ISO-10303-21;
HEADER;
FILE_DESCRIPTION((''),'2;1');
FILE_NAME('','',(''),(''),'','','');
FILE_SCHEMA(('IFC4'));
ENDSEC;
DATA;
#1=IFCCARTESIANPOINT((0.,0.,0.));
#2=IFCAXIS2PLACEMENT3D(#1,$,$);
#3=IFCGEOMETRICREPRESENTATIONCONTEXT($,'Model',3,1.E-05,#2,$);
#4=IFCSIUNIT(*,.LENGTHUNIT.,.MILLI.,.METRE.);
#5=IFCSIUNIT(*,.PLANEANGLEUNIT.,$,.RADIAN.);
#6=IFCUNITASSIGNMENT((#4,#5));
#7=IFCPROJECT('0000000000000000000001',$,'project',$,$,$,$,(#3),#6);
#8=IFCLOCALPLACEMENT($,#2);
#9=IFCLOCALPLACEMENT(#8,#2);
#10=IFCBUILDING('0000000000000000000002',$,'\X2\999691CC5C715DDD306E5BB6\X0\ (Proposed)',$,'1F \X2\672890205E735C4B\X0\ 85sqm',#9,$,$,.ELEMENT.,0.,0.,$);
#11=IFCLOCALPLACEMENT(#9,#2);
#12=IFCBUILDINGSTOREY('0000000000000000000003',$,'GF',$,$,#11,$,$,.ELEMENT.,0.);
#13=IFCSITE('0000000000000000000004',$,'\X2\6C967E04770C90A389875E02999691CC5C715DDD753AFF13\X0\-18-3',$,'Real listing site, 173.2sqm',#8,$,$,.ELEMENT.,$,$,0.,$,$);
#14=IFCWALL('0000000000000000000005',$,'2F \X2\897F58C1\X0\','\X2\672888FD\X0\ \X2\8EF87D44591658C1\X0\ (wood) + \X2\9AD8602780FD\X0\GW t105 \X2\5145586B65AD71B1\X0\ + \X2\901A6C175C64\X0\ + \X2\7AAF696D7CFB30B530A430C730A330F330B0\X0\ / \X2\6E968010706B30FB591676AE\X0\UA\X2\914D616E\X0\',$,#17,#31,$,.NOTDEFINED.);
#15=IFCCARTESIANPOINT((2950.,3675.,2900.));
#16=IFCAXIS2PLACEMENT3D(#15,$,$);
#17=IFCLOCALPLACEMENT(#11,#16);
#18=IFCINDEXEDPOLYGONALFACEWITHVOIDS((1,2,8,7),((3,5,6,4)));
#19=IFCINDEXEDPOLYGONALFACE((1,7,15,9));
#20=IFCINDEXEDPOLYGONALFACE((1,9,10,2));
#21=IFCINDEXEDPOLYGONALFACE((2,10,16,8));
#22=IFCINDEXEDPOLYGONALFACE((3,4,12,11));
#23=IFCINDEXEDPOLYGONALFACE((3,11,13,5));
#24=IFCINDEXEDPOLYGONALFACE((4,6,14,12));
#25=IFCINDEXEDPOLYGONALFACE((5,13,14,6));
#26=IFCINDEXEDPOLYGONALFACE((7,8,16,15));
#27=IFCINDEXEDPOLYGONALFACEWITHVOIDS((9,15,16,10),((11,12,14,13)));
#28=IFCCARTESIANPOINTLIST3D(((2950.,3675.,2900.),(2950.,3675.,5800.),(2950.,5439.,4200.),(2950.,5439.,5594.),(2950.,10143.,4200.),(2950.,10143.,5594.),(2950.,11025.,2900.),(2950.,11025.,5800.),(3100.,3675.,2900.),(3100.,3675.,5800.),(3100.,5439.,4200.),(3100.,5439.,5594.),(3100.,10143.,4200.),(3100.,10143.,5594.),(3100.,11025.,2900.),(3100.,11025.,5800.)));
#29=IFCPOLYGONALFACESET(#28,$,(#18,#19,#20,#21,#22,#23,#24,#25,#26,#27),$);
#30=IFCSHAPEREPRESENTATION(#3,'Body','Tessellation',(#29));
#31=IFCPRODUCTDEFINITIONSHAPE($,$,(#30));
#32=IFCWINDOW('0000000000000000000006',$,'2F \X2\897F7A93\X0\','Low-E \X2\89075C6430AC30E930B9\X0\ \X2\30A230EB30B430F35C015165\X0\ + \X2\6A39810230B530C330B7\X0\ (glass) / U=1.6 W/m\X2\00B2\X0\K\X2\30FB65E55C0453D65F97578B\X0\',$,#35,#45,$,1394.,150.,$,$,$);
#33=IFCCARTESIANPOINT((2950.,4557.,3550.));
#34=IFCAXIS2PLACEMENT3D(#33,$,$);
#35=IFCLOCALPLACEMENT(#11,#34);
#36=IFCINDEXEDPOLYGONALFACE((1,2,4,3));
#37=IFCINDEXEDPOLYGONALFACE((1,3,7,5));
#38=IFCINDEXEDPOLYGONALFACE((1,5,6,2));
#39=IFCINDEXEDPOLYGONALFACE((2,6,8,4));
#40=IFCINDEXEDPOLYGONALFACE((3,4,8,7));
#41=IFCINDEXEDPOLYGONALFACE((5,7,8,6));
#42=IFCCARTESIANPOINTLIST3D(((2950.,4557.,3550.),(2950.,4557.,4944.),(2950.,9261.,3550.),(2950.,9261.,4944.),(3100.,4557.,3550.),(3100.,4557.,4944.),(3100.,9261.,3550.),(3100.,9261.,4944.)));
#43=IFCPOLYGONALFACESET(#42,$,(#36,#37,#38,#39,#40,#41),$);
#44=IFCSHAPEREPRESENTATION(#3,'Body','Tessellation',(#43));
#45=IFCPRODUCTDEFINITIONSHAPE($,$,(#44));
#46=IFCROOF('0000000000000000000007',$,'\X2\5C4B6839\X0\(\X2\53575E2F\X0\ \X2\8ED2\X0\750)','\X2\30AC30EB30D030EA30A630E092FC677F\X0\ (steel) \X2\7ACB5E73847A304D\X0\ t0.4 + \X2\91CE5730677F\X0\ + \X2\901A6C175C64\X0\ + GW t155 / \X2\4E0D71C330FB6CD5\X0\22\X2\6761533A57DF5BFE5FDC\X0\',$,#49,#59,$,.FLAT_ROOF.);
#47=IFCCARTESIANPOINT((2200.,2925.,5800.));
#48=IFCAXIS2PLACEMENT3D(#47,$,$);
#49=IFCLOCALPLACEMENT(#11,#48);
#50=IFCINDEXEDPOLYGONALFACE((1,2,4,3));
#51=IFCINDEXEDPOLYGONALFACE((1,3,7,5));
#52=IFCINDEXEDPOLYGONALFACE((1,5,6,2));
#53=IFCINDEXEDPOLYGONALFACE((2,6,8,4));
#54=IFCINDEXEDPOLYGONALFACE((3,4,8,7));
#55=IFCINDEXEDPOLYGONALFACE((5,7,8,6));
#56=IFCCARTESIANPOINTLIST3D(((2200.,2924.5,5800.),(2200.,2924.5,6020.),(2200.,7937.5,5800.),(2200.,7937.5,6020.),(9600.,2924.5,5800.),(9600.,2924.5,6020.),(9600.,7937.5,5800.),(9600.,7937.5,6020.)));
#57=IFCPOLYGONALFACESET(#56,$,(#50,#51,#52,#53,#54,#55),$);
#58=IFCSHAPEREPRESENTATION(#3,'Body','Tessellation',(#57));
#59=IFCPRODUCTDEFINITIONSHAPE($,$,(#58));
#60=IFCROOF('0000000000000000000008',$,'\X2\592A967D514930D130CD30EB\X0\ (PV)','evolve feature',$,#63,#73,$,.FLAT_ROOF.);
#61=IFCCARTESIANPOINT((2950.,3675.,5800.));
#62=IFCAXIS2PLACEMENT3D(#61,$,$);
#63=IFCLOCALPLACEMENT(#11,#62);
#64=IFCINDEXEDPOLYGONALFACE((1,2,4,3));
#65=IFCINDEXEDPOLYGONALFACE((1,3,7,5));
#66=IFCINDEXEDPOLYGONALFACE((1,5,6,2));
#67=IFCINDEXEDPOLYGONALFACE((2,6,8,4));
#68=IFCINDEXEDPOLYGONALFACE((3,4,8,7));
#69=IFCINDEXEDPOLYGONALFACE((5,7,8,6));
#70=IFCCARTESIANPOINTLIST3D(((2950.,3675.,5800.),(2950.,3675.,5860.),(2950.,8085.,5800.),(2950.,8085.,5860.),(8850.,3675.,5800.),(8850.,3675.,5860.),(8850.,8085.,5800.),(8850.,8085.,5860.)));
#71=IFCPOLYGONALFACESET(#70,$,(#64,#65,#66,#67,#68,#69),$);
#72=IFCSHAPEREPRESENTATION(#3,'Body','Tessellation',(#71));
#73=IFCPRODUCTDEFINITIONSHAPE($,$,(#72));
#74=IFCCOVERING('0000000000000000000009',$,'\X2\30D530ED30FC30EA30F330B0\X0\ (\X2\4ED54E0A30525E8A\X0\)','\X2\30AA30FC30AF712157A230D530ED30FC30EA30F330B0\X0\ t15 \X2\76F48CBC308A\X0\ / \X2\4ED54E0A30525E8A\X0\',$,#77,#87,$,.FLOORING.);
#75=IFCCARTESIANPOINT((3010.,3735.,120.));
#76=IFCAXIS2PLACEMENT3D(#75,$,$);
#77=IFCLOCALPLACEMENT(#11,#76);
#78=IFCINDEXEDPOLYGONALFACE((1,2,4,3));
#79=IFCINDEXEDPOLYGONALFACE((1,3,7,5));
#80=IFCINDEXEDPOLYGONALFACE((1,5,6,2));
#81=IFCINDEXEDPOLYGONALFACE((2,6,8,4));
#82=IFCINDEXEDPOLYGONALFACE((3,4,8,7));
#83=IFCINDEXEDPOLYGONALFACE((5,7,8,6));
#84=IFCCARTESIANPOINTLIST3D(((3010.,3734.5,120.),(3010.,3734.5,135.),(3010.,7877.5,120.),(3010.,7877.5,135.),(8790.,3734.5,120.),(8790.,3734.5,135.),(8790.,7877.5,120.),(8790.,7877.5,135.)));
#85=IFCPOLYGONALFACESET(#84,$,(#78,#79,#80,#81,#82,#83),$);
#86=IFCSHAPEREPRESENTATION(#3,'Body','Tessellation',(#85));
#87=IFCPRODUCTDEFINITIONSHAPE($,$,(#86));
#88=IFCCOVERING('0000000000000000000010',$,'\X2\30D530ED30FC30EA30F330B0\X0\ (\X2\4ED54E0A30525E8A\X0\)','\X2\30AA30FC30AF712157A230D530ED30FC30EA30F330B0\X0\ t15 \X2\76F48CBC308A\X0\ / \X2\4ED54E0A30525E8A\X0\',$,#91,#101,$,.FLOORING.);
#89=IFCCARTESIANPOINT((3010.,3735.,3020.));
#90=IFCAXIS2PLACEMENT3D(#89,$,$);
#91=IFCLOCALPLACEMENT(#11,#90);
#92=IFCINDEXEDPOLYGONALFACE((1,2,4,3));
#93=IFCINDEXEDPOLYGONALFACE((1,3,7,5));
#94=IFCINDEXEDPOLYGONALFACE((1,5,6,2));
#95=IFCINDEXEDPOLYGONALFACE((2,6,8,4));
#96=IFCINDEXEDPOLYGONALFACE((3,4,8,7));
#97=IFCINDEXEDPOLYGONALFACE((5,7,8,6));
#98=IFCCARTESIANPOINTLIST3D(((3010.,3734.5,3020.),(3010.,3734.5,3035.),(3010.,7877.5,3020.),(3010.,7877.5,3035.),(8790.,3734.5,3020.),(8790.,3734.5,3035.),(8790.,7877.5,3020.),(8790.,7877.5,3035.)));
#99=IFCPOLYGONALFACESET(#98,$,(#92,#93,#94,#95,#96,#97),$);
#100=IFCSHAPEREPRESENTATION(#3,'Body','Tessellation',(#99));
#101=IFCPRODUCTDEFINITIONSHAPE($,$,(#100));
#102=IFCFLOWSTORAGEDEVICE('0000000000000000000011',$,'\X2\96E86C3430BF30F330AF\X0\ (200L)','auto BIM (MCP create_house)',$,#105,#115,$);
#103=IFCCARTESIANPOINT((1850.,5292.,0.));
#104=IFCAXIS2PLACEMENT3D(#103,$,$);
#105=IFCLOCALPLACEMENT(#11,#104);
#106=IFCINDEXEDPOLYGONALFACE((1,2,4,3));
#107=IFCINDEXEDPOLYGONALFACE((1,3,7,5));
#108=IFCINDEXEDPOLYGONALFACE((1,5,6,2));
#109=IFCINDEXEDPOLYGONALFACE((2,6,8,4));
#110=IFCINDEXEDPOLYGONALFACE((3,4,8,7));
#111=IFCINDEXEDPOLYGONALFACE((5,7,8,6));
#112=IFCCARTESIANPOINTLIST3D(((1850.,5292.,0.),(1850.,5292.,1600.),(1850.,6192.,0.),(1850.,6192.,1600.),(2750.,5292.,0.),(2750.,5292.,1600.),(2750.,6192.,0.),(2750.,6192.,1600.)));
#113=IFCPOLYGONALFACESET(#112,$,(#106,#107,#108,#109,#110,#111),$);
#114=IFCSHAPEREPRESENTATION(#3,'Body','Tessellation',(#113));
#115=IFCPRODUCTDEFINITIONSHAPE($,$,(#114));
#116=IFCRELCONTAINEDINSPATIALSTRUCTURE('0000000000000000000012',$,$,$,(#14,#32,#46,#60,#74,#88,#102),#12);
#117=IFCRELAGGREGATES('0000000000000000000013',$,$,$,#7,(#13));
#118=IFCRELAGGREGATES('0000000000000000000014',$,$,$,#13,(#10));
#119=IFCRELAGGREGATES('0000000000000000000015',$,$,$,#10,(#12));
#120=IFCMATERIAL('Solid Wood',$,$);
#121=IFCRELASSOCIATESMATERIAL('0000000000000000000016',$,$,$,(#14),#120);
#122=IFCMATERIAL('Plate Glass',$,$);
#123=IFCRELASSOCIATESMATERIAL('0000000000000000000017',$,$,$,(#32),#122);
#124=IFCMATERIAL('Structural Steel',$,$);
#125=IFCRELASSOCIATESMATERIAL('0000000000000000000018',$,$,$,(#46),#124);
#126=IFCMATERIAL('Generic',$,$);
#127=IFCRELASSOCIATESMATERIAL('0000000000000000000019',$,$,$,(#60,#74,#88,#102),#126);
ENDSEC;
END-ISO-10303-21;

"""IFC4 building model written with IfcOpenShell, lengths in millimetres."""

from ifc_helpers import new_model, si_unit, frame, frame_2d, origin, place, context, project, spatial, rectangle, extrude, material, element, fill, save


model = new_model("IFC4")

# Units and contexts
model_context = context("Model", 3, precision=1e-05, world=origin())
ifc_project = project(units=[si_unit("LENGTHUNIT", "METRE", prefix="MILLI"), si_unit("PLANEANGLEUNIT", "RADIAN")], contexts=[model_context])

# Site, building, storey
site_placement = place(None, origin())
site = spatial("IfcSite", under=ifc_project, at=site_placement, Name="沖縄県那覇市首里山川町３-18-3", ObjectType="Real listing site, 173.2sqm", CompositionType="ELEMENT", RefElevation=0.0)
building_placement = place(site_placement, origin())
building = spatial("IfcBuilding", under=site, at=building_placement, Name="首里山川の家 (Proposed)", ObjectType="1F 木造平屋 85sqm", CompositionType="ELEMENT", ElevationOfRefHeight=0.0, ElevationOfTerrain=0.0)
storey_placement = place(building_placement, origin())
storey = spatial("IfcBuildingStorey", under=building, at=storey_placement, Name="GF", CompositionType="ELEMENT", Elevation=0.0)

# Shared definitions
ifc_material_1 = material(Name="Solid Wood")
ifc_material_2 = material(Name="Generic")

# Shared definitions
ifc_material_3 = material(Name="Plate Glass")

# Wall, opening, window
wall_1_placement = place(storey_placement, frame((2950.0, 3675.0, 2900.0)))
wall_1 = element("IfcWall", 1, at=wall_1_placement, inside=storey, material=ifc_material_1, Name="2F 西壁", Description="木製 軸組外壁 (wood) + 高性能GW t105 充填断熱 + 通気層 + 窯業系サイディング / 準耐火・外皮UA配慮", PredefinedType="NOTDEFINED", context=model_context, shape_type="SweptSolid", body=[
    extrude(rectangle(XDim=150.0, YDim=7350.0, at=frame_2d((75.0, 3675.0))), frame((2950.0, 3675.0, 2900.0)), (0.0, 0.0, 1.0), 2900.0),
])
opening_1_placement = place(storey_placement, frame((2950.0, 4557.0, 3550.0)))
opening_1 = element("IfcOpeningElement", 2, at=opening_1_placement, cuts=wall_1, PredefinedType="NOTDEFINED", context=model_context, shape_type="SweptSolid", body=[
    extrude(rectangle(XDim=150.0, YDim=4704.0, at=frame_2d((75.0, 2352.0))), frame((2950.0, 4557.0, 3550.0)), (0.0, 0.0, 1.0), 1394.0),
])
window_1_placement = place(storey_placement, frame((2950.0, 4557.0, 3550.0)))
window_1 = element("IfcWindow", 3, at=window_1_placement, inside=storey, material=ifc_material_3, Name="2F 西窓", Description="Low-E 複層ガラス アルゴン封入 + 樹脂サッシ (glass) / U=1.6 W/m²K・日射取得型", OverallHeight=1394.0, OverallWidth=150.0, context=model_context, shape_type="SweptSolid", body=[
    extrude(rectangle(XDim=150.0, YDim=4704.0, at=frame_2d((75.0, 2352.0))), frame((2950.0, 4557.0, 3550.0)), (0.0, 0.0, 1.0), 1394.0),
])
fill(opening_1, window_1)

# Roofs
ifc_material_4 = material(Name="Structural Steel")
for number, where, name in (
    (4, (2200.0, 2925.0, 5800.0), "屋根(南帯 軒750)"),
):
    element("IfcRoof", number, at=place(storey_placement, frame(where)), inside=storey, material=ifc_material_4, Name=name, Description="ガルバリウム鋼板 (steel) 立平葺き t0.4 + 野地板 + 通気層 + GW t155 / 不燃・法22条区域対応", PredefinedType="FLAT_ROOF", context=model_context, shape_type="SweptSolid", body=[
        extrude(rectangle(XDim=7400.0, YDim=5013.0, at=frame_2d((3700.0, 2506.0))), frame((2200.0, 2925.0, 5800.0)), (0.0, 0.0, 1.0), 220.0),
    ])
roof_placement = place(storey_placement, frame((2950.0, 3675.0, 5800.0)))
element("IfcRoof", 5, at=roof_placement, inside=storey, material=ifc_material_2, Name="太陽光パネル (PV)", Description="evolve feature", PredefinedType="FLAT_ROOF", context=model_context, shape_type="SweptSolid", body=[
    extrude(rectangle(XDim=5900.0, YDim=4410.0, at=frame_2d((2950.0, 2205.0))), frame((2950.0, 3675.0, 5800.0)), (0.0, 0.0, 1.0), 60.0),
])

# Coverings
covering_1_placement = place(storey_placement, frame((3010.0, 3735.0, 120.0)))
element("IfcCovering", 6, at=covering_1_placement, inside=storey, material=ifc_material_2, Name="フローリング (仕上げ床)", Description="オーク無垢フローリング t15 直貼り / 仕上げ床", PredefinedType="FLOORING", context=model_context, shape_type="SweptSolid", body=[
    extrude(rectangle(XDim=5780.0, YDim=4143.0, at=frame_2d((2890.0, 2071.0))), frame((3010.0, 3735.0, 120.0)), (0.0, 0.0, 1.0), 15.0),
])
covering_2_placement = place(storey_placement, frame((3010.0, 3735.0, 3020.0)))
element("IfcCovering", 7, at=covering_2_placement, inside=storey, material=ifc_material_2, Name="フローリング (仕上げ床)", Description="オーク無垢フローリング t15 直貼り / 仕上げ床", PredefinedType="FLOORING", context=model_context, shape_type="SweptSolid", body=[
    extrude(rectangle(XDim=5780.0, YDim=4143.0, at=frame_2d((2890.0, 2071.0))), frame((3010.0, 3735.0, 3020.0)), (0.0, 0.0, 1.0), 15.0),
])

# Flow storage device
flow_storage_device_placement = place(storey_placement, frame((1850.0, 5292.0, 0.0)))
element("IfcFlowStorageDevice", 8, at=flow_storage_device_placement, inside=storey, material=ifc_material_2, Name="雨水タンク (200L)", Description="auto BIM (MCP create_house)", context=model_context, shape_type="SweptSolid", body=[
    extrude(rectangle(XDim=900.0, YDim=900.0, at=frame_2d((450.0, 450.0))), frame((1850.0, 5292.0, 0.0)), (0.0, 0.0, 1.0), 1600.0),
])

save(model, "model.ifc")
